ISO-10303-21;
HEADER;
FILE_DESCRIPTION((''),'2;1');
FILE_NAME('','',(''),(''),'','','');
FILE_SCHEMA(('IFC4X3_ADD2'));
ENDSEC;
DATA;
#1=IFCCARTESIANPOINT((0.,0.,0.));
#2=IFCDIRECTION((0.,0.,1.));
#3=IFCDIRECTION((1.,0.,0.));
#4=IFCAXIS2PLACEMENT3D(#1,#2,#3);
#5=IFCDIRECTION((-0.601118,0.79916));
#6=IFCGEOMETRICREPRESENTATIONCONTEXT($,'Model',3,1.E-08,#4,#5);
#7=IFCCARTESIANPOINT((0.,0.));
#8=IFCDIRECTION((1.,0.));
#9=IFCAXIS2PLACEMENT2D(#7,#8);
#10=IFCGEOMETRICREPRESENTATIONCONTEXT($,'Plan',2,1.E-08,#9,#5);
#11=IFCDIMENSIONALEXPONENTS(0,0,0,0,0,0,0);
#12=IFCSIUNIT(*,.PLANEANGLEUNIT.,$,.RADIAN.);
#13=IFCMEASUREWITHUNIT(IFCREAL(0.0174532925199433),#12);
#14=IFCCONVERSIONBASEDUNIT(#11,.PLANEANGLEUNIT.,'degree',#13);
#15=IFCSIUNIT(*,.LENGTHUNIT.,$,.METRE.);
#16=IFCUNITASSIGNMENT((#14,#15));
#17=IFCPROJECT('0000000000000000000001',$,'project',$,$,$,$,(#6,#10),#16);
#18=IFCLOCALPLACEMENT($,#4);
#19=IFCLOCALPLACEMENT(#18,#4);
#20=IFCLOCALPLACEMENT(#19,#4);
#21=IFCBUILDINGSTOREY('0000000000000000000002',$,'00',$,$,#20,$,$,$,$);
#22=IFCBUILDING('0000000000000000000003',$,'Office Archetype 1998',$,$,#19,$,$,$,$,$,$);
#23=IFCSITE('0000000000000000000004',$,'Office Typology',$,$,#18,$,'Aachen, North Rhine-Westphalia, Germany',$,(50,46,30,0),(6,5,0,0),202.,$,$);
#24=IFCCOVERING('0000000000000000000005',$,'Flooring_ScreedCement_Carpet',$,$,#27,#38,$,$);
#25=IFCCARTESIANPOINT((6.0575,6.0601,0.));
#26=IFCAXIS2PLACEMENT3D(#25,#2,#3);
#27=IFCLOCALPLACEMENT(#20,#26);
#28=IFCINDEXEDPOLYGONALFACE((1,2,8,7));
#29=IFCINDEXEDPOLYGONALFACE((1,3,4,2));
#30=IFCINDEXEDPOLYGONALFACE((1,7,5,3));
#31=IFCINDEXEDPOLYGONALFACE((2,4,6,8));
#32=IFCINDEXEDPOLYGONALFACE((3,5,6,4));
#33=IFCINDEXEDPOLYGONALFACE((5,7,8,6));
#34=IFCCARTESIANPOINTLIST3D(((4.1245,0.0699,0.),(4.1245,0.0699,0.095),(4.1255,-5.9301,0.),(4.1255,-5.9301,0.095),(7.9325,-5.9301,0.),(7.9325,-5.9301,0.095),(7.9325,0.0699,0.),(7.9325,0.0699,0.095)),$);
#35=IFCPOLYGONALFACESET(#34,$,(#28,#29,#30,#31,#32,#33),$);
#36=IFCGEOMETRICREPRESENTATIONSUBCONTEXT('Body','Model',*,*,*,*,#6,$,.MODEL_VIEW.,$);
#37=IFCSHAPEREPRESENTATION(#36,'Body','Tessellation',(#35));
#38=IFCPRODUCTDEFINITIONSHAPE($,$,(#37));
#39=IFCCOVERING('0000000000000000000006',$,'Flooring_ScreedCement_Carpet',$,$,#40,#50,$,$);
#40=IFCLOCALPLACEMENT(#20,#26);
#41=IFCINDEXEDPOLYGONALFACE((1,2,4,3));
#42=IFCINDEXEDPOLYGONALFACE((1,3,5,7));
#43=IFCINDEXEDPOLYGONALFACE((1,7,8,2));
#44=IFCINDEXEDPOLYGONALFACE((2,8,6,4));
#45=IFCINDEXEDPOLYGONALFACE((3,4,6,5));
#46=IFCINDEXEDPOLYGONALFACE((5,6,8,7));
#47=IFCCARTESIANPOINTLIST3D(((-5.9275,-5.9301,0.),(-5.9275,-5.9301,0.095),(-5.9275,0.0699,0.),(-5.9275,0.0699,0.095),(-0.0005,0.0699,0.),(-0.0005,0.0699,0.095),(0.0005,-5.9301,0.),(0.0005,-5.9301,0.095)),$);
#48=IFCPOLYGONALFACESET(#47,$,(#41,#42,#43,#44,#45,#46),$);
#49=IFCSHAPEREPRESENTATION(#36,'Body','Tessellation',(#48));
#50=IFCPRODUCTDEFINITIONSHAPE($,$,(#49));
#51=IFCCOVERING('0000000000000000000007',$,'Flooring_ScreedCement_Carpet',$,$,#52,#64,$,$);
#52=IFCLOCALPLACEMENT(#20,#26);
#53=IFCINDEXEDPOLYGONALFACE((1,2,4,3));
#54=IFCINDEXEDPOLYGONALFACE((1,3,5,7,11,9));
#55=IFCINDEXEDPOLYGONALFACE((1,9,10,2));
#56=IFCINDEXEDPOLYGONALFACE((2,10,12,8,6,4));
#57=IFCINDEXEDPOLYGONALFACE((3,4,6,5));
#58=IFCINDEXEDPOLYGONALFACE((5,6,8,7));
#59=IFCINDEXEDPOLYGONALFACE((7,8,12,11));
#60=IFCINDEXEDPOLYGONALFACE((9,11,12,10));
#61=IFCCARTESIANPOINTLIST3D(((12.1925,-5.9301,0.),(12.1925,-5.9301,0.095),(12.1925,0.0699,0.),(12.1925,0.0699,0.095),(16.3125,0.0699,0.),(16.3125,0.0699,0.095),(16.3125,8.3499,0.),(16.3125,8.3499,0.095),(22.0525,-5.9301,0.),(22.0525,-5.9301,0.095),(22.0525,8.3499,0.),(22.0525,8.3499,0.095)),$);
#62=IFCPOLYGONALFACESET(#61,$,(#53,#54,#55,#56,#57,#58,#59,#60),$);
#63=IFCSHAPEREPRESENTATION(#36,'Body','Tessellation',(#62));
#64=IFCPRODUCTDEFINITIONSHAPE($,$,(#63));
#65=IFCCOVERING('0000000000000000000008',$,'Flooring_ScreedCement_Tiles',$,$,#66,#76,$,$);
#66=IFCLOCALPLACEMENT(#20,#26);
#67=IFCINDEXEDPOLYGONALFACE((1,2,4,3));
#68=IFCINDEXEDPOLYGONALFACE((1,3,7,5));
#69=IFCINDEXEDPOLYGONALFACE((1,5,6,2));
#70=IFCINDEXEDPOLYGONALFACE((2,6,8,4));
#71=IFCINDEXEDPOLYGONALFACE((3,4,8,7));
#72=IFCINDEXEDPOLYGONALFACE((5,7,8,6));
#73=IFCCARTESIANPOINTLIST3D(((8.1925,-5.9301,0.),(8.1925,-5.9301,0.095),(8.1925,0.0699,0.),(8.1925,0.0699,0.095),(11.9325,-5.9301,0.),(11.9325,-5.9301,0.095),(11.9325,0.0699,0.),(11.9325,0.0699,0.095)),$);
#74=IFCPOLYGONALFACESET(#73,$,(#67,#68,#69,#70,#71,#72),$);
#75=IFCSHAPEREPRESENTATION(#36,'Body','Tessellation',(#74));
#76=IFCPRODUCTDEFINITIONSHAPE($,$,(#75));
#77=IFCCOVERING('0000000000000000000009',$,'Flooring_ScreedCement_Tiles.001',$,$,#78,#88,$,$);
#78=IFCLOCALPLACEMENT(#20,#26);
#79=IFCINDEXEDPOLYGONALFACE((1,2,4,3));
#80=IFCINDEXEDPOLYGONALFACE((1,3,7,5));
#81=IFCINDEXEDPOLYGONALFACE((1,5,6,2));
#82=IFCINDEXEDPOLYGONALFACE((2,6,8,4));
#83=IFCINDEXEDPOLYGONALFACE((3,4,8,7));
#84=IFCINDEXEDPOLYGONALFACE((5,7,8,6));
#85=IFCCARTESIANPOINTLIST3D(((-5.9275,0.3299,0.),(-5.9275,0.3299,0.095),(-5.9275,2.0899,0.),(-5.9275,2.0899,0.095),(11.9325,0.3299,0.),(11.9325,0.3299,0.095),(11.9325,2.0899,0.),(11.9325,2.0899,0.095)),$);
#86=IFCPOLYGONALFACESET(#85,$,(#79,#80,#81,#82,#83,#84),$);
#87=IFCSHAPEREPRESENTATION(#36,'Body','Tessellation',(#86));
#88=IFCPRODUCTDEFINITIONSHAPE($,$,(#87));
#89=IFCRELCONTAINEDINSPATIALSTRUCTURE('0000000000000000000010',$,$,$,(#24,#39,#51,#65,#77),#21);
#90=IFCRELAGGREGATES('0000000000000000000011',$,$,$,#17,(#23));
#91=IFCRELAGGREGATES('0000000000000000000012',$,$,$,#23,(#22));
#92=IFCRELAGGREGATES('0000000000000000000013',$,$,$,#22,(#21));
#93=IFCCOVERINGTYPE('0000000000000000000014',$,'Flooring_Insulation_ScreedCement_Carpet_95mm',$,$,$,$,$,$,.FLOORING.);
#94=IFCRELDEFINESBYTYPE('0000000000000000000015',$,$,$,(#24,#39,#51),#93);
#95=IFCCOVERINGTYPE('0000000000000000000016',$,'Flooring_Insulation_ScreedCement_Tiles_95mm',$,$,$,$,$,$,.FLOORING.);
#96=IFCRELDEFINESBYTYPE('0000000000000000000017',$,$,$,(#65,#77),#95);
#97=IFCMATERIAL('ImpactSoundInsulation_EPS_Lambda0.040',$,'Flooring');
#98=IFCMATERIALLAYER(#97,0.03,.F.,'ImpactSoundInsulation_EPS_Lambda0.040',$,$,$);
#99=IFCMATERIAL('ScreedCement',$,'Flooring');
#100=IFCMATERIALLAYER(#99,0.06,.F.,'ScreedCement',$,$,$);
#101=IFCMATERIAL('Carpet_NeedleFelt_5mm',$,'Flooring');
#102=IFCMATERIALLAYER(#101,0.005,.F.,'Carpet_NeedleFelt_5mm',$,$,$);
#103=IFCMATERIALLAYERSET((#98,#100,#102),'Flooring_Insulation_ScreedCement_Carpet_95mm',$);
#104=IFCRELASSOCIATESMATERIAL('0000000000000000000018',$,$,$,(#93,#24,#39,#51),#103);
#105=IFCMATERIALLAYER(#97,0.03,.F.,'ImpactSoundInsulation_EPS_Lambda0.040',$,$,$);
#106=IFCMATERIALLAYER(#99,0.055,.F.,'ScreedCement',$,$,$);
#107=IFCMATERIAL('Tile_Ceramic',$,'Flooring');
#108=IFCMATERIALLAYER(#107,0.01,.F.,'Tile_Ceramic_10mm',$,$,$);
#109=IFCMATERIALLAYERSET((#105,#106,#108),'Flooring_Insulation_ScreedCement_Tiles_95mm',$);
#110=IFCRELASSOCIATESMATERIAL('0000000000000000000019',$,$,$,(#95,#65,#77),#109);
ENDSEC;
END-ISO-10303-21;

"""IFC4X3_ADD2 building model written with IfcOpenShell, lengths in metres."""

from ifc_helpers import new_model, entity, si_unit, converted_unit, direction, frame, origin_with_axes, origin_2d_with_axis, place, context, subcontext, project, spatial, line, indexed_curve, outline, extrude, material, layer, layer_set, layer_usage, type_object, element, save


model = new_model("IFC4X3_ADD2")

# Units and contexts
model_context = context("Model", 3, precision=1e-08, world=origin_with_axes(), true_north=direction((-0.601118, 0.79916)))
plan_context = context("Plan", 2, precision=1e-08, world=origin_2d_with_axis(), true_north=direction((-0.601118, 0.79916)))
body_context = subcontext(model_context, "Body", "Model", "MODEL_VIEW")
ifc_project = project(units=[converted_unit("PLANEANGLEUNIT", "degree", entity("IfcReal", 0.0174532925199433), si_unit("PLANEANGLEUNIT", "RADIAN"), dimensions=[0, 0, 0, 0, 0, 0, 0]), si_unit("LENGTHUNIT", "METRE")], contexts=[model_context, plan_context])

# Site, building, storey
site_placement = place(None, origin_with_axes())
site = spatial("IfcSite", under=ifc_project, at=site_placement, Name="Office Typology", LongName="Aachen, North Rhine-Westphalia, Germany", RefLatitude=(50, 46, 30, 0), RefLongitude=(6, 5, 0, 0), RefElevation=202.0)
building_placement = place(site_placement, origin_with_axes())
building = spatial("IfcBuilding", under=site, at=building_placement, Name="Office Archetype 1998")
storey_placement = place(building_placement, origin_with_axes())
storey = spatial("IfcBuildingStorey", under=building, at=storey_placement, Name="00")

# Coverings
ifc_material_1 = material(Name="ImpactSoundInsulation_EPS_Lambda0.040", Category="Flooring")
ifc_layer_1 = layer(ifc_material_1, 0.03, ventilated=False, Name="ImpactSoundInsulation_EPS_Lambda0.040")
ifc_material_2 = material(Name="ScreedCement", Category="Flooring")
ifc_layer_2 = layer(ifc_material_2, 0.06, ventilated=False, Name="ScreedCement")
ifc_material_3 = material(Name="Carpet_NeedleFelt_5mm", Category="Flooring")
ifc_layer_3 = layer(ifc_material_3, 0.005, ventilated=False, Name="Carpet_NeedleFelt_5mm")
ifc_layer_set_1 = layer_set([ifc_layer_1, ifc_layer_2, ifc_layer_3], Name="Flooring_Insulation_ScreedCement_Carpet_95mm")
ifc_layer_usage_1 = layer_usage(ifc_layer_set_1, "AXIS3", "POSITIVE", 0.0)
covering_type_1 = type_object("IfcCoveringType", Name="Flooring_Insulation_ScreedCement_Carpet_95mm", PredefinedType="FLOORING", material=ifc_layer_set_1)
covering_1_placement = place(storey_placement, frame((6.0575, 6.0601, 0.0), z_axis=(0.0, 0.0, 1.0), x_axis=(1.0, 0.0, 0.0)))
element("IfcCovering", 1, at=covering_1_placement, inside=storey, type_object=covering_type_1, material=ifc_layer_usage_1, Name="Flooring_ScreedCement_Carpet", context=body_context, shape_type="SweptSolid", body=[
    extrude(outline(indexed_curve([(4.1245, 0.0699), (7.9325, 0.0699), (7.9325, -5.9301), (4.1255, -5.9301)], segments=[line(1, 2, 3, 4, 1)])), origin_with_axes(), (0.0, 0.0, 1.0), 0.095),
])
ifc_layer_usage_2 = layer_usage(ifc_layer_set_1, "AXIS3", "POSITIVE", 0.0)
covering_2_placement = place(storey_placement, frame((6.0575, 6.0601, 0.0), z_axis=(0.0, 0.0, 1.0), x_axis=(1.0, 0.0, 0.0)))
element("IfcCovering", 2, at=covering_2_placement, inside=storey, type_object=covering_type_1, material=ifc_layer_usage_2, Name="Flooring_ScreedCement_Carpet", context=body_context, shape_type="SweptSolid", body=[
    extrude(outline(indexed_curve([(-5.9275, -5.9301), (-5.9275, 0.0699), (-0.0005, 0.0699), (0.0005, -5.9301)], segments=[line(1, 2, 3, 4, 1)])), origin_with_axes(), (0.0, 0.0, 1.0), 0.095),
])
ifc_layer_usage_3 = layer_usage(ifc_layer_set_1, "AXIS3", "POSITIVE", 0.0)
covering_3_placement = place(storey_placement, frame((6.0575, 6.0601, 0.0), z_axis=(0.0, 0.0, 1.0), x_axis=(1.0, 0.0, 0.0)))
element("IfcCovering", 3, at=covering_3_placement, inside=storey, type_object=covering_type_1, material=ifc_layer_usage_3, Name="Flooring_ScreedCement_Carpet", context=body_context, shape_type="SweptSolid", body=[
    extrude(outline(indexed_curve([(16.3125, 8.3499), (22.0525, 8.3499), (22.0525, -5.9301), (12.1925, -5.9301), (12.1925, 0.0699), (16.3125, 0.0699)], segments=[line(1, 2, 3, 4, 5, 6, 1)])), origin_with_axes(), (0.0, 0.0, 1.0), 0.095),
])
ifc_layer_4 = layer(ifc_material_1, 0.03, ventilated=False, Name="ImpactSoundInsulation_EPS_Lambda0.040")
ifc_layer_5 = layer(ifc_material_2, 0.055, ventilated=False, Name="ScreedCement")
ifc_material_4 = material(Name="Tile_Ceramic", Category="Flooring")
ifc_layer_6 = layer(ifc_material_4, 0.01, ventilated=False, Name="Tile_Ceramic_10mm")
ifc_layer_set_2 = layer_set([ifc_layer_4, ifc_layer_5, ifc_layer_6], Name="Flooring_Insulation_ScreedCement_Tiles_95mm")
ifc_layer_usage_4 = layer_usage(ifc_layer_set_2, "AXIS3", "POSITIVE", 0.0)
covering_type_2 = type_object("IfcCoveringType", Name="Flooring_Insulation_ScreedCement_Tiles_95mm", PredefinedType="FLOORING", material=ifc_layer_set_2)
covering_4_placement = place(storey_placement, frame((6.0575, 6.0601, 0.0), z_axis=(0.0, 0.0, 1.0), x_axis=(1.0, 0.0, 0.0)))
element("IfcCovering", 4, at=covering_4_placement, inside=storey, type_object=covering_type_2, material=ifc_layer_usage_4, Name="Flooring_ScreedCement_Tiles", context=body_context, shape_type="SweptSolid", body=[
    extrude(outline(indexed_curve([(8.1925, 0.0699), (11.9325, 0.0699), (11.9325, -5.9301), (8.1925, -5.9301)], segments=[line(1, 2, 3, 4, 1)])), origin_with_axes(), (0.0, 0.0, 1.0), 0.095),
])
ifc_layer_usage_5 = layer_usage(ifc_layer_set_2, "AXIS3", "POSITIVE", 0.0)
covering_5_placement = place(storey_placement, frame((6.0575, 6.0601, 0.0), z_axis=(0.0, 0.0, 1.0), x_axis=(1.0, 0.0, 0.0)))
element("IfcCovering", 5, at=covering_5_placement, inside=storey, type_object=covering_type_2, material=ifc_layer_usage_5, Name="Flooring_ScreedCement_Tiles.001", context=body_context, shape_type="SweptSolid", body=[
    extrude(outline(indexed_curve([(-5.9275, 0.3299), (-5.9275, 2.0899), (11.9325, 2.0899), (11.9325, 0.3299)], segments=[line(1, 2, 3, 4, 1)])), None, (0.0, 0.0, 1.0), 0.095),
])

save(model, "model.ifc")
